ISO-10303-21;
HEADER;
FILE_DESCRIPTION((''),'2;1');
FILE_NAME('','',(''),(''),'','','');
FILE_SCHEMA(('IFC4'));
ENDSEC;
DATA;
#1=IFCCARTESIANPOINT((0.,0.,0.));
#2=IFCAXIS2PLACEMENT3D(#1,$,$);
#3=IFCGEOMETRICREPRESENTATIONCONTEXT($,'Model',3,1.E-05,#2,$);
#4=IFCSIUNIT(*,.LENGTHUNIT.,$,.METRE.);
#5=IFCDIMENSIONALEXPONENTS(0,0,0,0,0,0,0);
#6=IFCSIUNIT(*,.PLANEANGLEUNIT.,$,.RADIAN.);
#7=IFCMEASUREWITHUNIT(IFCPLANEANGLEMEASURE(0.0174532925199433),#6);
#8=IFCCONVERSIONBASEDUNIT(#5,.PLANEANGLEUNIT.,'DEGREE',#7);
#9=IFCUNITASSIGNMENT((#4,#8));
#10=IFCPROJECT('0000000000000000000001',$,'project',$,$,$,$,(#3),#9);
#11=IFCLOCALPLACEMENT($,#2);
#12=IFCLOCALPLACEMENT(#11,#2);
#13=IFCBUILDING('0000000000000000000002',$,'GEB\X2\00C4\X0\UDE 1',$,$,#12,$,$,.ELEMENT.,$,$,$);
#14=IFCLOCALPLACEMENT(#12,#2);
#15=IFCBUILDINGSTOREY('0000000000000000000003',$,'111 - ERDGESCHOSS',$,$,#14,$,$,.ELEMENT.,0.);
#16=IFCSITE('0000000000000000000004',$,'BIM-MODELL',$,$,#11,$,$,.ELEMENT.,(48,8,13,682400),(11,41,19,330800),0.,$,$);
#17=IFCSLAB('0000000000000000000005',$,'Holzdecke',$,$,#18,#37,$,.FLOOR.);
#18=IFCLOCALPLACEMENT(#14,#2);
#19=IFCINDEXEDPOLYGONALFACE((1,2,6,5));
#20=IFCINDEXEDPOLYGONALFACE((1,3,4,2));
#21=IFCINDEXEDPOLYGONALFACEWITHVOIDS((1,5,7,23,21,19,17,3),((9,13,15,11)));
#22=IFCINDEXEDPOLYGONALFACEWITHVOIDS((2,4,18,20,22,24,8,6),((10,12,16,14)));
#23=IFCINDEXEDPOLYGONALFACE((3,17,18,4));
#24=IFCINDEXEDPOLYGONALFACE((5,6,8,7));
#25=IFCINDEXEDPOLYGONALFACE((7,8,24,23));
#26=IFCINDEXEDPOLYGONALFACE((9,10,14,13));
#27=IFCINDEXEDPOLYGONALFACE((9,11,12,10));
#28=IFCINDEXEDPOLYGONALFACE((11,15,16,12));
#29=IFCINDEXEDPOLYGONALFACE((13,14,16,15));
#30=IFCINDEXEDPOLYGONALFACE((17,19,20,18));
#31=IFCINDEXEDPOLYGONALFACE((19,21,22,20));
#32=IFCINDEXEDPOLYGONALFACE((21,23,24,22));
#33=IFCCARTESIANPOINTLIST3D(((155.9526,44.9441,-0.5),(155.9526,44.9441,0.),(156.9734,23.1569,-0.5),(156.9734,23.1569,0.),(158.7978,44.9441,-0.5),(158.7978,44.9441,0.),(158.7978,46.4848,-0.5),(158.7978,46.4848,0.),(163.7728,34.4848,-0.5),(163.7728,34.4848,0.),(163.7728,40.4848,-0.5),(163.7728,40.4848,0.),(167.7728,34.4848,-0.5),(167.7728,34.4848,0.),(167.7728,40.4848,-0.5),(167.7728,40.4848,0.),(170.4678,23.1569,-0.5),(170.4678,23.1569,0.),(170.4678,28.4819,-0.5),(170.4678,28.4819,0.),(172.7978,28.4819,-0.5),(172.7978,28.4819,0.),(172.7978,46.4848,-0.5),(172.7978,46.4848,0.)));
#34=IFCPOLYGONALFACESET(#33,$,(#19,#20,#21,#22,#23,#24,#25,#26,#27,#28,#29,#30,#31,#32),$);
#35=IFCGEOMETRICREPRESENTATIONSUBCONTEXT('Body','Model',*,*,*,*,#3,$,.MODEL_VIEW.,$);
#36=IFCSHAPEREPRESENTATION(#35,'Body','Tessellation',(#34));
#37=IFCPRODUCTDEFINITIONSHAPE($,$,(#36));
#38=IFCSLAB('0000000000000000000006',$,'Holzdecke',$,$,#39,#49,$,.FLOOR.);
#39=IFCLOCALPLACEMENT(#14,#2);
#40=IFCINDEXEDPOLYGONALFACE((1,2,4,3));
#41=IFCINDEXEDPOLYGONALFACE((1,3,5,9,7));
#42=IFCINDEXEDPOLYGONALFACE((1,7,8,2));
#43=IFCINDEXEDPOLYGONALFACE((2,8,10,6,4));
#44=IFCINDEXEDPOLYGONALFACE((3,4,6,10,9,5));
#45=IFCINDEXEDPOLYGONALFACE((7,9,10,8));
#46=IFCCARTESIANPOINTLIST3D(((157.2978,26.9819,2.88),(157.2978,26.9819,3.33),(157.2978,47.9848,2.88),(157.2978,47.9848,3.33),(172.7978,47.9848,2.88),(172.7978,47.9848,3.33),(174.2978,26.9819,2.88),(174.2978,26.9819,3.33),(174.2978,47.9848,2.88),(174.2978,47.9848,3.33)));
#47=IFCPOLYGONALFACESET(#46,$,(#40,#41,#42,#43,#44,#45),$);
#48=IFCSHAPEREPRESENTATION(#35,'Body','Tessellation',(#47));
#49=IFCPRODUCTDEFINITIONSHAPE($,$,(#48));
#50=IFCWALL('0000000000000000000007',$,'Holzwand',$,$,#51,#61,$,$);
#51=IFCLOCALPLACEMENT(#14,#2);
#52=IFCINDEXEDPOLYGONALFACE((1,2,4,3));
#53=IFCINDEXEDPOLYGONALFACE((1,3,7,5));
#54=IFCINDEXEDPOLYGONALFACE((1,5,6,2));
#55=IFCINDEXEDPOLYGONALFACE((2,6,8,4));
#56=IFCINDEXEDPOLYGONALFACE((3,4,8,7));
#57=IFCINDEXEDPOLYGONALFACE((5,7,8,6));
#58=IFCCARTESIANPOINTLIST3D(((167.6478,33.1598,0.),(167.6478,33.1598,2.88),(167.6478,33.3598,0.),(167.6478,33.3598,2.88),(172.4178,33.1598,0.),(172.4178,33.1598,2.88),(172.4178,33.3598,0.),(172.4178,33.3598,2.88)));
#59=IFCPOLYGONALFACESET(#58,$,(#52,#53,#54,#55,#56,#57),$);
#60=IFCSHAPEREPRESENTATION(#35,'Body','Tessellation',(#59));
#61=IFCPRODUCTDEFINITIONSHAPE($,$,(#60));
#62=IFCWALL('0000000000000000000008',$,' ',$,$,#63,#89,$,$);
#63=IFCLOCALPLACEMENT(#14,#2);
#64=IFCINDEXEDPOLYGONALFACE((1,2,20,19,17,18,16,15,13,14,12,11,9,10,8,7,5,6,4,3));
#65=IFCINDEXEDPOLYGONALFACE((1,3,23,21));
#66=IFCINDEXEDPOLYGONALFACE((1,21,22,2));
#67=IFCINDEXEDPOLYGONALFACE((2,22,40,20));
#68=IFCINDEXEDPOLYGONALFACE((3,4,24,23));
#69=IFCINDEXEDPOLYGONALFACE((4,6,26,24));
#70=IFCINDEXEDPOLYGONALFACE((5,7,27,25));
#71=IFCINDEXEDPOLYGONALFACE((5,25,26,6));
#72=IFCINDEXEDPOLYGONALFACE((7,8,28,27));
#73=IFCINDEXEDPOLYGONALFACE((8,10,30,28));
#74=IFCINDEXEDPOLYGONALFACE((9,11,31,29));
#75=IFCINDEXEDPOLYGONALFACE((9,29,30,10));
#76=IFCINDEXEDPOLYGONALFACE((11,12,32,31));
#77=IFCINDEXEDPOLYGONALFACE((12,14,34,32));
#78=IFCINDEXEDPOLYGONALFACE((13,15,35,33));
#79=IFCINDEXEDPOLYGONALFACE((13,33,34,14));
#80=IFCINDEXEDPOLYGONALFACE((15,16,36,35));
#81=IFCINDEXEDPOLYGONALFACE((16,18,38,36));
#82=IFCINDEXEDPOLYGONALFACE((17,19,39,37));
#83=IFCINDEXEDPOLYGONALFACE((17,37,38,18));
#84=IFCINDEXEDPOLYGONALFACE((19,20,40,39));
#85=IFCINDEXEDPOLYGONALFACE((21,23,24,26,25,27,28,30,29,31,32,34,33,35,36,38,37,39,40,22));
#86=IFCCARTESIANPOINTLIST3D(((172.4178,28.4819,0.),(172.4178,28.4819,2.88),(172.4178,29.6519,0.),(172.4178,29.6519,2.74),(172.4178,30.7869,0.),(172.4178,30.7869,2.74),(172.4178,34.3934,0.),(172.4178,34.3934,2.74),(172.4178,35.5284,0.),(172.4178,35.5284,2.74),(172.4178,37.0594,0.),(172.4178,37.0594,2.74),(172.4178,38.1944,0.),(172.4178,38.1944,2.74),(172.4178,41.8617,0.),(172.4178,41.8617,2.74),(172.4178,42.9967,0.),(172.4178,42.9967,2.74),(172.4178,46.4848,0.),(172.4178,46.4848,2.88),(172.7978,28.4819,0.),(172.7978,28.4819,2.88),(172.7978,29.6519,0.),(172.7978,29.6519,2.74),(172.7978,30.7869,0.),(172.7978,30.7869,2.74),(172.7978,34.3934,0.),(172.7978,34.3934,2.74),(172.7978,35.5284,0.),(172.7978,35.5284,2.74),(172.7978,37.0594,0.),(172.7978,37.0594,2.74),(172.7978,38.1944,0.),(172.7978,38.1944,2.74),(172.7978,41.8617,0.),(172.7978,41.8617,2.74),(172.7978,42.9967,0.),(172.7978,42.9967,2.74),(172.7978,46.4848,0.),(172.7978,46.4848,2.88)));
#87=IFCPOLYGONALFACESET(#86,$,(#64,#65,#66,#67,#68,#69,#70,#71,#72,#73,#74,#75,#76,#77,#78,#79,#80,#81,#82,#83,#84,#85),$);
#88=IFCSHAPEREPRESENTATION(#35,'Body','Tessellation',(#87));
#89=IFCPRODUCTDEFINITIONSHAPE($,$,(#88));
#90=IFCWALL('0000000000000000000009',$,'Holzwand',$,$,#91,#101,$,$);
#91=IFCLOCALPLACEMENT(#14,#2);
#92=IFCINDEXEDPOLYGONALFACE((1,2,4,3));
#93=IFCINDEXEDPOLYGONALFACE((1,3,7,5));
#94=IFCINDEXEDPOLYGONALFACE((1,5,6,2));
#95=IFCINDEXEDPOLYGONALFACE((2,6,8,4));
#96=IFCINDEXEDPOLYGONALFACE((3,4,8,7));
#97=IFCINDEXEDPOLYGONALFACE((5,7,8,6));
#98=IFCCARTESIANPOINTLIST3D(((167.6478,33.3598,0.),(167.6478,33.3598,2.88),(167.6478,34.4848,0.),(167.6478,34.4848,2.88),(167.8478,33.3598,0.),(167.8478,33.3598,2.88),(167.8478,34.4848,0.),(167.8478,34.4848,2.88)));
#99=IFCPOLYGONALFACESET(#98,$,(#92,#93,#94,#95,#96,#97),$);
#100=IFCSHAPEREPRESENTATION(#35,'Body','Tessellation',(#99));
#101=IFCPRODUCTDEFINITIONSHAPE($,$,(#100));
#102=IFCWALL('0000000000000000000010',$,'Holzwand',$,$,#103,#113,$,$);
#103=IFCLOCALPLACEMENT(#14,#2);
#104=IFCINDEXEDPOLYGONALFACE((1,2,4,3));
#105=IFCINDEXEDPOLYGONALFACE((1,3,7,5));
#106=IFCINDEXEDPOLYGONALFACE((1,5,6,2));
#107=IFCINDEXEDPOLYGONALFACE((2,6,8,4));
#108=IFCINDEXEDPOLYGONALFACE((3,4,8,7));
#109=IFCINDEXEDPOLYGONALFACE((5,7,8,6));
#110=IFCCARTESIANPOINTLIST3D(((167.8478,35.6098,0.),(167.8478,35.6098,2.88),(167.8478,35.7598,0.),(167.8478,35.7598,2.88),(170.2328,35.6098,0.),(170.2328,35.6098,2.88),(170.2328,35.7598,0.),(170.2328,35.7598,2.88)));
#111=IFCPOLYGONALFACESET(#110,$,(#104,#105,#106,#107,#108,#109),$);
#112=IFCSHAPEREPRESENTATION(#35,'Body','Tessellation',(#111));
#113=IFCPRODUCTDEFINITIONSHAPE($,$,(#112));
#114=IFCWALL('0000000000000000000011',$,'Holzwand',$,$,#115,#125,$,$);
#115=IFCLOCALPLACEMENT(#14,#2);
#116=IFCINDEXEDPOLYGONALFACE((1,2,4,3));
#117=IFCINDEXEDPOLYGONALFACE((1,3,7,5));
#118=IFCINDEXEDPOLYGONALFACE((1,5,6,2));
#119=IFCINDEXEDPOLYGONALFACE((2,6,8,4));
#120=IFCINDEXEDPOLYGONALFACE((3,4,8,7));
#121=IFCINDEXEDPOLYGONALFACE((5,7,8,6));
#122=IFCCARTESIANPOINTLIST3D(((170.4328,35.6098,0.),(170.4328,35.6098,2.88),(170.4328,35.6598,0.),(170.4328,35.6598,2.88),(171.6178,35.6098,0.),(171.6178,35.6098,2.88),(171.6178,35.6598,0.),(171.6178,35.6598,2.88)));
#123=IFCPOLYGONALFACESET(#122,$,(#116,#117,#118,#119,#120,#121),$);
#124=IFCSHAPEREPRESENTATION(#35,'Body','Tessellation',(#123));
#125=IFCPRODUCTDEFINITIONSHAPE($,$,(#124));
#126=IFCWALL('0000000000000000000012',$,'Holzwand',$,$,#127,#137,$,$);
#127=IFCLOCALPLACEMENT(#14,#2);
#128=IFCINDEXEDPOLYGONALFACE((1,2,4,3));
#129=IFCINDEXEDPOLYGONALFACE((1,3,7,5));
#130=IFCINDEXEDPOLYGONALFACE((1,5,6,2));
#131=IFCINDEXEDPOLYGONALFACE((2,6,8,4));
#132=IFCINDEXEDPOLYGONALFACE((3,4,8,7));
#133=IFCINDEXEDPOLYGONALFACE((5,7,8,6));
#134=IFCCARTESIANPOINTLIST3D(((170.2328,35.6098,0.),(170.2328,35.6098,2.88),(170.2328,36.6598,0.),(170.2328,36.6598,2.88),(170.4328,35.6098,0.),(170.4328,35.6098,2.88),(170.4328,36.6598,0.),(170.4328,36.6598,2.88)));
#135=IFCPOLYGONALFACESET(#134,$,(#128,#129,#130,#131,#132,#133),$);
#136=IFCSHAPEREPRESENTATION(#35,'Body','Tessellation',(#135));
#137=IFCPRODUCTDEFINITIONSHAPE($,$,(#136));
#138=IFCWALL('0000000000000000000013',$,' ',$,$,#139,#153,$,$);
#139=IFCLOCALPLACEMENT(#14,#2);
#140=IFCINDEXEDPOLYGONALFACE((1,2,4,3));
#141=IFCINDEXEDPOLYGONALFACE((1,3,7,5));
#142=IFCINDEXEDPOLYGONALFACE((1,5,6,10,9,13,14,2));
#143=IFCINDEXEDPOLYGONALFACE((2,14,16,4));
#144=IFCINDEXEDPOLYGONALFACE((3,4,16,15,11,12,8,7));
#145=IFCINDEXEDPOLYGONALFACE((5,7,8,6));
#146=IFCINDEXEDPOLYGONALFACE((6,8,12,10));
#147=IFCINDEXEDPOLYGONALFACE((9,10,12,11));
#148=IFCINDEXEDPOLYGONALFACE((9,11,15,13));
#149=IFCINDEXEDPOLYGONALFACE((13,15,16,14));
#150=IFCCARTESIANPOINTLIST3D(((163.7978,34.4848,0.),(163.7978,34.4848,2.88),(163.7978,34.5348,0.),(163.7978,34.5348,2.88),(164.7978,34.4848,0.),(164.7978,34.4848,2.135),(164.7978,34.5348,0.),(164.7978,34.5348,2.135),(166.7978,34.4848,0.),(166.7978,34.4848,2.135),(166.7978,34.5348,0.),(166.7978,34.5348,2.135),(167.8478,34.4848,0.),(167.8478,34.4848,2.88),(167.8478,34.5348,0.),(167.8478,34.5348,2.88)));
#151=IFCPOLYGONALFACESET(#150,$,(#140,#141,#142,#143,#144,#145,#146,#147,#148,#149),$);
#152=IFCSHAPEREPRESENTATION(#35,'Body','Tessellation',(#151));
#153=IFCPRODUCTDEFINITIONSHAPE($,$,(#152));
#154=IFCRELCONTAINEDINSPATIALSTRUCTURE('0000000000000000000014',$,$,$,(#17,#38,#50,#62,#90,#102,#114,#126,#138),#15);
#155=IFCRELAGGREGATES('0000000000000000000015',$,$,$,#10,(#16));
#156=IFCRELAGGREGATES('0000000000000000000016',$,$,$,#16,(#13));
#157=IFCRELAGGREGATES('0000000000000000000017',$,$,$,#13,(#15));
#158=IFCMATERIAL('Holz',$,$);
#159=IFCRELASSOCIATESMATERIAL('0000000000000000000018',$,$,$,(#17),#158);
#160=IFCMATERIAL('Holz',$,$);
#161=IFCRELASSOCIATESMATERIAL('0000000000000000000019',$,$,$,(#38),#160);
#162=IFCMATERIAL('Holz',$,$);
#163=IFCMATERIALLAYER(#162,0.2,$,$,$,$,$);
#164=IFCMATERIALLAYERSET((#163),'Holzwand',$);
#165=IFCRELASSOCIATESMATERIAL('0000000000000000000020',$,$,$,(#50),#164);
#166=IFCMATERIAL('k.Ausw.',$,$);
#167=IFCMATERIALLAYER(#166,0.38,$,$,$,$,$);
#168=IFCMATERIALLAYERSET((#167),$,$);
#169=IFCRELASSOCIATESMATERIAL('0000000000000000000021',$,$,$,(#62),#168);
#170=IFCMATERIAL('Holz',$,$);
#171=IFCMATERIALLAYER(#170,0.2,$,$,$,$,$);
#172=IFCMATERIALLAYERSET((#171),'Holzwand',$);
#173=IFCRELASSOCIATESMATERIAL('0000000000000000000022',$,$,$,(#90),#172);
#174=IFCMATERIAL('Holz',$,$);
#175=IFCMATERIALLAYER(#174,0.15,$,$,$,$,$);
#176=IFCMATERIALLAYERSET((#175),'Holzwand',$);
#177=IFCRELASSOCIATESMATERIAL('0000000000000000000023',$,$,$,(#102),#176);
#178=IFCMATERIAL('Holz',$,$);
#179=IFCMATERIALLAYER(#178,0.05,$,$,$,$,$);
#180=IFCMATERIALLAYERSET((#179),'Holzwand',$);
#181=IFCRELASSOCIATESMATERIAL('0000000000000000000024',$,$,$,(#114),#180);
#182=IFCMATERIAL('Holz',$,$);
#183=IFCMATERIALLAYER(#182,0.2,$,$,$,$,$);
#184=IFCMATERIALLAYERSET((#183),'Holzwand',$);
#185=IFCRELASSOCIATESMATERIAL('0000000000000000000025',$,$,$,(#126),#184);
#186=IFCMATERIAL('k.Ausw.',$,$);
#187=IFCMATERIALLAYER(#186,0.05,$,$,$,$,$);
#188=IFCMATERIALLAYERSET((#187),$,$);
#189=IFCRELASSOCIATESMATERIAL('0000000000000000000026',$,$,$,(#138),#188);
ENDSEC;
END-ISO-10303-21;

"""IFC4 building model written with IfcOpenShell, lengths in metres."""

from ifc_helpers import new_model, entity, si_unit, converted_unit, frame, frame_2d, origin, origin_with_axes, place, context, subcontext, project, spatial, polyline, rectangle, outline, extrude, material, layer, layer_set, layer_usage, element, save


model = new_model("IFC4")

# Units and contexts
model_context = context("Model", 3, precision=1e-05, world=origin())
body_context = subcontext(model_context, "Body", "Model", "MODEL_VIEW")
ifc_project = project(units=[si_unit("LENGTHUNIT", "METRE"), converted_unit("PLANEANGLEUNIT", "DEGREE", entity("IfcPlaneAngleMeasure", 0.0174532925199433), si_unit("PLANEANGLEUNIT", "RADIAN"), dimensions=[0, 0, 0, 0, 0, 0, 0])], contexts=[model_context])

# Site, building, storey
site_placement = place(None, origin())
site = spatial("IfcSite", under=ifc_project, at=site_placement, Name="BIM-MODELL", CompositionType="ELEMENT", RefLatitude=(48, 8, 13, 682400), RefLongitude=(11, 41, 19, 330800), RefElevation=0.0)
building_placement = place(site_placement, origin())
building = spatial("IfcBuilding", under=site, at=building_placement, Name="GEBÄUDE 1", CompositionType="ELEMENT")
storey_placement = place(building_placement, origin())
storey = spatial("IfcBuildingStorey", under=building, at=storey_placement, Name="111 - ERDGESCHOSS", CompositionType="ELEMENT", Elevation=0.0)

# Slabs
ifc_material_1 = material(Name="Holz")
slab_1_placement = place(storey_placement, frame((155.9526, 23.1569, -0.5)))
element("IfcSlab", 1, at=slab_1_placement, inside=storey, material=ifc_material_1, Name="Holzdecke", PredefinedType="FLOOR", context=body_context, shape_type="SweptSolid", body=[
    extrude(outline(polyline([(0.0, 21.7872), (1.0208, 0.0), (14.5152, 0.0), (14.5152, 5.3251), (16.8452, 5.3251), (16.8452, 23.3279), (2.8452, 23.3279), (2.8452, 21.7872), (0.0, 21.7872)]), holes=[polyline([(7.8202, 17.3279), (11.8202, 17.3279), (11.8202, 11.3279), (7.8202, 11.3279), (7.8202, 17.3279)])]), origin_with_axes(), (0.0, 0.0, 1.0), 0.5),
])
ifc_material_2 = material(Name="Holz")
slab_2_placement = place(storey_placement, frame((157.2978, 26.9819, 2.88)))
element("IfcSlab", 2, at=slab_2_placement, inside=storey, material=ifc_material_2, Name="Holzdecke", PredefinedType="FLOOR", context=body_context, shape_type="SweptSolid", body=[
    extrude(outline(polyline([(17.0, 0.0), (17.0, 21.0029), (15.5, 21.0029), (0.0, 21.0029), (0.0, 0.0), (17.0, 0.0)])), origin_with_axes(), (0.0, 0.0, 1.0), 0.45),
])

# Wall
ifc_material_3 = material(Name="Holz")
ifc_layer_1 = layer(ifc_material_3, 0.2)
ifc_layer_set_1 = layer_set([ifc_layer_1], Name="Holzwand")
ifc_layer_usage_1 = layer_usage(ifc_layer_set_1, "AXIS2", "POSITIVE", 0.0)
wall_1_placement = place(storey_placement, frame((167.6478, 33.1598, 0.0)))
element("IfcWall", 3, at=wall_1_placement, inside=storey, material=ifc_layer_usage_1, Name="Holzwand", context=body_context, shape_type="SweptSolid", body=[
    extrude(rectangle(XDim=4.77, YDim=0.2, at=frame_2d((2.385, 0.1), x_axis=(1.0, 0.0))), origin_with_axes(), (0.0, 0.0, 1.0), 2.88),
])

# Wall, openings
ifc_material_4 = material(Name="k.Ausw.")
ifc_layer_2 = layer(ifc_material_4, 0.38)
ifc_layer_set_2 = layer_set([ifc_layer_2])
ifc_layer_usage_2 = layer_usage(ifc_layer_set_2, "AXIS2", "POSITIVE", 0.0)
wall_2_placement = place(storey_placement, frame((172.7978, 28.4819, 0.0), z_axis=(0.0, 0.0, 1.0), x_axis=(0.0, 1.0, 0.0)))
wall_2 = element("IfcWall", 4, at=wall_2_placement, inside=storey, material=ifc_layer_usage_2, Name=" ", context=body_context, shape_type="SweptSolid", body=[
    extrude(rectangle(XDim=18.0029, YDim=0.38, at=frame_2d((9.0014, 0.19), x_axis=(1.0, 0.0))), origin_with_axes(), (0.0, 0.0, 1.0), 2.88),
])
opening_1_placement = place(wall_2_placement, frame((1.17, 0.0, 0.0), z_axis=(0.0, 1.0, 0.0), x_axis=(0.0, 0.0, 1.0)))
element("IfcOpeningElement", 5, at=opening_1_placement, cuts=wall_2, ObjectType="Opening", context=body_context, shape_type="SweptSolid", body=[
    extrude(outline(polyline([(0.0, 1.135), (2.74, 1.135), (2.74, 0.0), (0.0, 0.0), (0.0, 1.135)])), origin_with_axes(), (0.0, 0.0, 1.0), 0.38),
])
opening_2_placement = place(wall_2_placement, frame((5.9114, 0.0, 0.0), z_axis=(0.0, 1.0, 0.0), x_axis=(0.0, 0.0, 1.0)))
element("IfcOpeningElement", 6, at=opening_2_placement, cuts=wall_2, ObjectType="Opening", context=body_context, shape_type="SweptSolid", body=[
    extrude(outline(polyline([(0.0, 1.135), (2.74, 1.135), (2.74, 0.0), (0.0, 0.0), (0.0, 1.135)])), origin_with_axes(), (0.0, 0.0, 1.0), 0.38),
])
opening_3_placement = place(wall_2_placement, frame((8.5775, 0.0, 0.0), z_axis=(0.0, 1.0, 0.0), x_axis=(0.0, 0.0, 1.0)))
element("IfcOpeningElement", 7, at=opening_3_placement, cuts=wall_2, ObjectType="Opening", context=body_context, shape_type="SweptSolid", body=[
    extrude(outline(polyline([(0.0, 1.135), (2.74, 1.135), (2.74, 0.0), (0.0, 0.0), (0.0, 1.135)])), origin_with_axes(), (0.0, 0.0, 1.0), 0.38),
])
opening_4_placement = place(wall_2_placement, frame((13.3798, 0.0, 0.0), z_axis=(0.0, 1.0, 0.0), x_axis=(0.0, 0.0, 1.0)))
element("IfcOpeningElement", 8, at=opening_4_placement, cuts=wall_2, ObjectType="Opening", context=body_context, shape_type="SweptSolid", body=[
    extrude(outline(polyline([(0.0, 1.135), (2.74, 1.135), (2.74, 0.0), (0.0, 0.0), (0.0, 1.135)])), origin_with_axes(), (0.0, 0.0, 1.0), 0.38),
])

# Wall
ifc_material_5 = material(Name="Holz")
ifc_layer_3 = layer(ifc_material_5, 0.2)
ifc_layer_set_3 = layer_set([ifc_layer_3], Name="Holzwand")
ifc_layer_usage_3 = layer_usage(ifc_layer_set_3, "AXIS2", "POSITIVE", 0.0)
wall_3_placement = place(storey_placement, frame((167.8478, 33.3598, 0.0), z_axis=(0.0, 0.0, 1.0), x_axis=(0.0, 1.0, 0.0)))
element("IfcWall", 9, at=wall_3_placement, inside=storey, material=ifc_layer_usage_3, Name="Holzwand", context=body_context, shape_type="SweptSolid", body=[
    extrude(rectangle(XDim=1.125, YDim=0.2, at=frame_2d((0.5625, 0.1), x_axis=(1.0, 0.0))), origin_with_axes(), (0.0, 0.0, 1.0), 2.88),
])

# Walls
ifc_material_6 = material(Name="Holz")
ifc_layer_4 = layer(ifc_material_6, 0.15)
ifc_layer_set_4 = layer_set([ifc_layer_4], Name="Holzwand")
ifc_layer_usage_4 = layer_usage(ifc_layer_set_4, "AXIS2", "POSITIVE", 0.0)
wall_4_placement = place(storey_placement, frame((167.8478, 35.6098, 0.0)))
element("IfcWall", 10, at=wall_4_placement, inside=storey, material=ifc_layer_usage_4, Name="Holzwand", context=body_context, shape_type="SweptSolid", body=[
    extrude(rectangle(XDim=2.385, YDim=0.15, at=frame_2d((1.1925, 0.075), x_axis=(1.0, 0.0))), origin_with_axes(), (0.0, 0.0, 1.0), 2.88),
])
ifc_material_7 = material(Name="Holz")
ifc_layer_5 = layer(ifc_material_7, 0.05)
ifc_layer_set_5 = layer_set([ifc_layer_5], Name="Holzwand")
ifc_layer_usage_5 = layer_usage(ifc_layer_set_5, "AXIS2", "POSITIVE", 0.0)
wall_5_placement = place(storey_placement, frame((171.6178, 35.6598, 0.0), z_axis=(0.0, 0.0, 1.0), x_axis=(-1.0, 0.0, 0.0)))
element("IfcWall", 11, at=wall_5_placement, inside=storey, material=ifc_layer_usage_5, Name="Holzwand", context=body_context, shape_type="SweptSolid", body=[
    extrude(rectangle(XDim=1.185, YDim=0.05, at=frame_2d((0.5925, 0.025), x_axis=(1.0, 0.0))), origin_with_axes(), (0.0, 0.0, 1.0), 2.88),
])
ifc_material_8 = material(Name="Holz")
ifc_layer_6 = layer(ifc_material_8, 0.2)
ifc_layer_set_6 = layer_set([ifc_layer_6], Name="Holzwand")
ifc_layer_usage_6 = layer_usage(ifc_layer_set_6, "AXIS2", "POSITIVE", -0.075)
wall_6_placement = place(storey_placement, frame((170.4328, 35.6098, 0.0), z_axis=(0.0, 0.0, 1.0), x_axis=(0.0, 1.0, 0.0)))
element("IfcWall", 12, at=wall_6_placement, inside=storey, material=ifc_layer_usage_6, Name="Holzwand", context=body_context, shape_type="SweptSolid", body=[
    extrude(rectangle(XDim=1.05, YDim=0.2, at=frame_2d((0.525, 0.1), x_axis=(1.0, 0.0))), origin_with_axes(), (0.0, 0.0, 1.0), 2.88),
])

# Wall, opening
ifc_material_9 = material(Name="k.Ausw.")
ifc_layer_7 = layer(ifc_material_9, 0.05)
ifc_layer_set_7 = layer_set([ifc_layer_7])
ifc_layer_usage_7 = layer_usage(ifc_layer_set_7, "AXIS2", "POSITIVE", 0.0)
wall_7_placement = place(storey_placement, frame((163.7978, 34.4848, 0.0), z_axis=(0.0, 0.0, 1.0), x_axis=(1.0, 0.0, 0.0)))
wall_7 = element("IfcWall", 13, at=wall_7_placement, inside=storey, material=ifc_layer_usage_7, Name=" ", context=body_context, shape_type="SweptSolid", body=[
    extrude(rectangle(XDim=4.05, YDim=0.05, at=frame_2d((2.025, 0.025), x_axis=(1.0, 0.0))), origin_with_axes(), (0.0, 0.0, 1.0), 2.88),
])
opening_5_placement = place(wall_7_placement, frame((1.0, 0.0, 0.0), z_axis=(0.0, 1.0, 0.0), x_axis=(0.0, 0.0, 1.0)))
element("IfcOpeningElement", 14, at=opening_5_placement, cuts=wall_7, ObjectType="Opening", context=body_context, shape_type="SweptSolid", body=[
    extrude(outline(polyline([(0.0, 2.0), (2.135, 2.0), (2.135, 0.0), (0.0, 0.0), (0.0, 2.0)])), origin_with_axes(), (0.0, 0.0, 1.0), 0.05),
])

save(model, "model.ifc")
